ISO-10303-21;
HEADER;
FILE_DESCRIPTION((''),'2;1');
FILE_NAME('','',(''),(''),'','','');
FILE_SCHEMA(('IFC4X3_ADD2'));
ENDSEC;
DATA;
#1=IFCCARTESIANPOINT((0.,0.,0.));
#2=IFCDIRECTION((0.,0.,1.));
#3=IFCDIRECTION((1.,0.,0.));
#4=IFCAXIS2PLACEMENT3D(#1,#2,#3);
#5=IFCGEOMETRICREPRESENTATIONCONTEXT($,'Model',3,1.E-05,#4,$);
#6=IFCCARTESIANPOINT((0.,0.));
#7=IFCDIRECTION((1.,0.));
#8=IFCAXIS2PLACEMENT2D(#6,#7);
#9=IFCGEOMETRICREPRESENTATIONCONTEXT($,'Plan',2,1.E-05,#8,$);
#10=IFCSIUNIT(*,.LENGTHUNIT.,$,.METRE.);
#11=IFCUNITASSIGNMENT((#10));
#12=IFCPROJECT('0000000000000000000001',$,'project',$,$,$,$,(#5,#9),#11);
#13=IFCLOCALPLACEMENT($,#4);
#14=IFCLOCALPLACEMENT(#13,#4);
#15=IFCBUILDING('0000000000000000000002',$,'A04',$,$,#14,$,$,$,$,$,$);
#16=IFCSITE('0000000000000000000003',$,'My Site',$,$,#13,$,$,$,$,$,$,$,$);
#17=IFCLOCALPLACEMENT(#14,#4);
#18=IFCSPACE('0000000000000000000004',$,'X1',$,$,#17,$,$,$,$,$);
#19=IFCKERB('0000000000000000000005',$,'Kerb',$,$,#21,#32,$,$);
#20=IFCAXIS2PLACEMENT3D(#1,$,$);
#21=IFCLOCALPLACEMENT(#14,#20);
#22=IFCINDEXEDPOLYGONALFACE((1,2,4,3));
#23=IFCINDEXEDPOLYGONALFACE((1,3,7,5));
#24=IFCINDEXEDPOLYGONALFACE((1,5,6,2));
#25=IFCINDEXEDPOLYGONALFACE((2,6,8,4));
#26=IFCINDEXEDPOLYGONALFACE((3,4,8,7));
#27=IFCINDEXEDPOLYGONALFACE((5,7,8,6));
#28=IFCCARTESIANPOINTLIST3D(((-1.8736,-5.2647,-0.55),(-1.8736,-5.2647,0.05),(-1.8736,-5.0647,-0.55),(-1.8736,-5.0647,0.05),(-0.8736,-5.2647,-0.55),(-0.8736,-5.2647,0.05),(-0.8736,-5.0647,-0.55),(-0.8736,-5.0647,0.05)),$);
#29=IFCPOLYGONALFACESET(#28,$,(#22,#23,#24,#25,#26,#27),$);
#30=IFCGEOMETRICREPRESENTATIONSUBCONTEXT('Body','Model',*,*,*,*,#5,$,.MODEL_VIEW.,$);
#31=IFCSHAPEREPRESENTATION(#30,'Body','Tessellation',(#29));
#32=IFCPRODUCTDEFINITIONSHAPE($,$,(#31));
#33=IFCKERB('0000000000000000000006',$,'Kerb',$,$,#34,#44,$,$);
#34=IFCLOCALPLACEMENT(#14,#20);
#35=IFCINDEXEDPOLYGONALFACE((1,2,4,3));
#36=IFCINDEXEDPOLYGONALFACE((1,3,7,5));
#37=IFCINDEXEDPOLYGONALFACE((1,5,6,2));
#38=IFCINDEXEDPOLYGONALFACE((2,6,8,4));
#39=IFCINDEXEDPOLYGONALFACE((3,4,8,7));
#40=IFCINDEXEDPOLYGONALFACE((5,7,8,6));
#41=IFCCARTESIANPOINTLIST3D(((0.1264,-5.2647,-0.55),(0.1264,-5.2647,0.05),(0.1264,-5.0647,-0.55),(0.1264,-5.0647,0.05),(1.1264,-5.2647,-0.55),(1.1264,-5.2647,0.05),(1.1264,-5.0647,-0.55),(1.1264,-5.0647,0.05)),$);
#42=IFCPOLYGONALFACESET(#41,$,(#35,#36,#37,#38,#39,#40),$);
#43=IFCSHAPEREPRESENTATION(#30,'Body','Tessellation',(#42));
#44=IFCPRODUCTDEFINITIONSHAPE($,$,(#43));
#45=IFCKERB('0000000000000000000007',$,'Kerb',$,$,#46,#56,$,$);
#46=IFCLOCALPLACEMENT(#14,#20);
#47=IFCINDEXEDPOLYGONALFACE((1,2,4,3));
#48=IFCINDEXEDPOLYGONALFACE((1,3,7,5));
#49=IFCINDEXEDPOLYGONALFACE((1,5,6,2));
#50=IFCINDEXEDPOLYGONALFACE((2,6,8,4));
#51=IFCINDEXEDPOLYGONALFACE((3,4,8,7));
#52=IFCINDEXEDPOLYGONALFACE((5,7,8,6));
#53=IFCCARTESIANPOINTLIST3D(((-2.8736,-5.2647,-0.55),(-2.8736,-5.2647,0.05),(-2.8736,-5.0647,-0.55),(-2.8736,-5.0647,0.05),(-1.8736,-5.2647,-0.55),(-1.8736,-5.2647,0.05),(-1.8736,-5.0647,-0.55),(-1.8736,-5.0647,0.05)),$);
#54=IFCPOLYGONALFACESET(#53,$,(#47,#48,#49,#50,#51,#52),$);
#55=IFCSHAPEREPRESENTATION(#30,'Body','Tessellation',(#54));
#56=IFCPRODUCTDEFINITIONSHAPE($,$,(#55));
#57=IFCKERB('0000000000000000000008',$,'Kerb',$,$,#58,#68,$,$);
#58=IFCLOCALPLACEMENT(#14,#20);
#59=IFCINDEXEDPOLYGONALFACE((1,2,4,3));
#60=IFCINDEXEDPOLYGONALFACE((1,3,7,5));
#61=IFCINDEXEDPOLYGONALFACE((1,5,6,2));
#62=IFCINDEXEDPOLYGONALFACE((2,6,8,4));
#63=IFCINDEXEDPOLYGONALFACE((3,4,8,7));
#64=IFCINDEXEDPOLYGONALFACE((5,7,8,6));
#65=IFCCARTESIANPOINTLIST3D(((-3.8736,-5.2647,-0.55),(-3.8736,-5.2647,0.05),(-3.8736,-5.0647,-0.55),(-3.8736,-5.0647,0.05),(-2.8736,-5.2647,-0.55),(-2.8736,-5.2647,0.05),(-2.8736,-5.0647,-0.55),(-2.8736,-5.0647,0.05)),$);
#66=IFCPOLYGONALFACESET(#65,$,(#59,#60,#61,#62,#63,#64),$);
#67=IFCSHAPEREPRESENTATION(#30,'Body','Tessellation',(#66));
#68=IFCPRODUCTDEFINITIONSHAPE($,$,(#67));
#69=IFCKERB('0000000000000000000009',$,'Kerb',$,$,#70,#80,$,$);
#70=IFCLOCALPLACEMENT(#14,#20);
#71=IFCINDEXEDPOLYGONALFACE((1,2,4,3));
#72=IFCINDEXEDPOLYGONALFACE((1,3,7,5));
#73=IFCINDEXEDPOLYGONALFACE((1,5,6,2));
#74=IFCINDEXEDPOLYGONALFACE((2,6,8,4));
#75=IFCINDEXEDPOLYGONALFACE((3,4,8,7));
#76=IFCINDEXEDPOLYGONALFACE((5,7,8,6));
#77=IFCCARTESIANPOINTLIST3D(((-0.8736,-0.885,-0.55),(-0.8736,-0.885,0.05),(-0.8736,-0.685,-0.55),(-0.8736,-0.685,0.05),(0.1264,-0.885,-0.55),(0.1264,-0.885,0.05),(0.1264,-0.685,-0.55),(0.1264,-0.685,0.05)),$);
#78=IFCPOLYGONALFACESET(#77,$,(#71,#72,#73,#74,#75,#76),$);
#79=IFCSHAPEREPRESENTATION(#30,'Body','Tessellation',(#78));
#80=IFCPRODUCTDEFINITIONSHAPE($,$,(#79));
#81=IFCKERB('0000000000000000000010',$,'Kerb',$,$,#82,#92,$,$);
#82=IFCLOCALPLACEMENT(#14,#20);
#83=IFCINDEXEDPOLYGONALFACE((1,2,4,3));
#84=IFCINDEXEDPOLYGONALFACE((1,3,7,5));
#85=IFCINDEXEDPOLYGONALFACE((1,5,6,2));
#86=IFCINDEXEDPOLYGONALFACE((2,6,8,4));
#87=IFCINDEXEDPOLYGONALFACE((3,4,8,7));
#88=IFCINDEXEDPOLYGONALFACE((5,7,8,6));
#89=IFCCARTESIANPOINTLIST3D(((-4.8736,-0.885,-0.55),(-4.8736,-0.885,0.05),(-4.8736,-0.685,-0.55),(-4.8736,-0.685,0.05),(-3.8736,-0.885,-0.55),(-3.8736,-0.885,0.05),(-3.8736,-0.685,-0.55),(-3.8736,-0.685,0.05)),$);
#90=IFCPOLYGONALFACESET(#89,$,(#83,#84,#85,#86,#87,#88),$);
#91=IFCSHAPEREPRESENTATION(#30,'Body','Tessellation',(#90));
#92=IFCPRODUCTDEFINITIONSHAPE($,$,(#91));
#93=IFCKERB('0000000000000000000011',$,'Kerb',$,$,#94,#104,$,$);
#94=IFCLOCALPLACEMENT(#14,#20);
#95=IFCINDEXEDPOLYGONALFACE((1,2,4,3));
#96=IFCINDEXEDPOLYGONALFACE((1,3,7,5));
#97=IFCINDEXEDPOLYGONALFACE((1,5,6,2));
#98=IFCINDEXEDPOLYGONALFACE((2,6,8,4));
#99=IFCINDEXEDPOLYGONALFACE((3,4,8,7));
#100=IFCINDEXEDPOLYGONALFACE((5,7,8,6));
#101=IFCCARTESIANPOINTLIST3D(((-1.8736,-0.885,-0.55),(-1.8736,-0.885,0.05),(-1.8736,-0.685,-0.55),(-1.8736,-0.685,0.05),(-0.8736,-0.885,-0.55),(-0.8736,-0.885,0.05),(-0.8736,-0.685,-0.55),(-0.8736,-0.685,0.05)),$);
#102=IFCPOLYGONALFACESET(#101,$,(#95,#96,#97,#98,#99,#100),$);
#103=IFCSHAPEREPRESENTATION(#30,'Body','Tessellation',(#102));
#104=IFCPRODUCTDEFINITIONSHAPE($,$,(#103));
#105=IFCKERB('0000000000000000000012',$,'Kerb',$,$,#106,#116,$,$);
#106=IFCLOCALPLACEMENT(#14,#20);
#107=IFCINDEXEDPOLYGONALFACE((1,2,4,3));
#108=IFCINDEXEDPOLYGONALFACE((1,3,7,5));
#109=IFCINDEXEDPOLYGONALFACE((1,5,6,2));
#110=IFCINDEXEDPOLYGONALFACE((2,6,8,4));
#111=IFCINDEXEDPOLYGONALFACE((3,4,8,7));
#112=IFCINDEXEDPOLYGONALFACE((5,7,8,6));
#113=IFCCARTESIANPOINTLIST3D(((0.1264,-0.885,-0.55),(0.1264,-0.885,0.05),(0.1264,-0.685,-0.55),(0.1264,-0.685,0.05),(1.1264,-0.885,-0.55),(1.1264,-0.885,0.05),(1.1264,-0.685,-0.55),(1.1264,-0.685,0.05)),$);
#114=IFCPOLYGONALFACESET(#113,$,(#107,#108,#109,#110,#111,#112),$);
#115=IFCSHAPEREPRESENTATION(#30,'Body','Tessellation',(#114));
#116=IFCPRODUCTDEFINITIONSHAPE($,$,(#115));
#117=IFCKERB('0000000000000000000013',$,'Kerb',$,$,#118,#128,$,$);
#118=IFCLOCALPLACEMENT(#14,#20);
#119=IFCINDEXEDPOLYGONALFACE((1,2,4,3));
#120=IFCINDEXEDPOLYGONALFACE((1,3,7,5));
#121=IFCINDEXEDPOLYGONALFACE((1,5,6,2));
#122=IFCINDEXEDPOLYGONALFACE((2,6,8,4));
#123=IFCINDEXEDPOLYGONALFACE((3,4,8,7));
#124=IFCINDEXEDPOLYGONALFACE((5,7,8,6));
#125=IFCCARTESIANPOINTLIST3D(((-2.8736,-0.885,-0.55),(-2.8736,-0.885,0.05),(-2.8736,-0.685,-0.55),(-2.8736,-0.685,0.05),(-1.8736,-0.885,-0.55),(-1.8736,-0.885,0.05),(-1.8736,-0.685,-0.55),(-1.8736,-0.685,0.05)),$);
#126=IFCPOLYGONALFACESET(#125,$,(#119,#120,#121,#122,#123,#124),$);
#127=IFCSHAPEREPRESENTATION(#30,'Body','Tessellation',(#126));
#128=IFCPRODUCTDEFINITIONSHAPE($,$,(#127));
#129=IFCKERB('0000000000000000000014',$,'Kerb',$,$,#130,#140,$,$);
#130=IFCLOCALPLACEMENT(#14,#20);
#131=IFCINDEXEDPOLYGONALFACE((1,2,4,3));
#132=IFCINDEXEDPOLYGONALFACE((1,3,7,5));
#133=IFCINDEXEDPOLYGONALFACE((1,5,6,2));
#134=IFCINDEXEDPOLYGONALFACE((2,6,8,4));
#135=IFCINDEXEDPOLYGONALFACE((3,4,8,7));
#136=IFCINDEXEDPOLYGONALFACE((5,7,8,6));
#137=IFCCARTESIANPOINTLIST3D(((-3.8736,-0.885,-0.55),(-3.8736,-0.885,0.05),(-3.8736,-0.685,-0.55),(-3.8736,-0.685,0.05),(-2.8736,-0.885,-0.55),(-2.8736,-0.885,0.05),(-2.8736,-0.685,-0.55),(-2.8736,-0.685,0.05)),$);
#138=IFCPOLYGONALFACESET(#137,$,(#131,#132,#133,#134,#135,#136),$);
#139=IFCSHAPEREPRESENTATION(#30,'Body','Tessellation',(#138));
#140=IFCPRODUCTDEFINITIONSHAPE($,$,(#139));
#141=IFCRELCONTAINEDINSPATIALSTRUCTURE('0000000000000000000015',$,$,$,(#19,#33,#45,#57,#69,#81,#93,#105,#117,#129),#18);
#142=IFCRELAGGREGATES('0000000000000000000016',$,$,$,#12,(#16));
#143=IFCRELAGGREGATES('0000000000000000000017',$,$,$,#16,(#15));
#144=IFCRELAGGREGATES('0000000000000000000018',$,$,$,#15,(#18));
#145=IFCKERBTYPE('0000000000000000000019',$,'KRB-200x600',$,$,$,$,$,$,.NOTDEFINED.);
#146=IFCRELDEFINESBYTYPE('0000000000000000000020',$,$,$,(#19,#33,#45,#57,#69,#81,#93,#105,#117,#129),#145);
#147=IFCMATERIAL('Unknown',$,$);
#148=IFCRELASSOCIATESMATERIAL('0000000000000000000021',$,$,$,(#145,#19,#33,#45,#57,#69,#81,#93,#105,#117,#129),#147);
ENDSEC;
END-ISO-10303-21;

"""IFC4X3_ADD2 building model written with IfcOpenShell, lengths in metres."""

from ifc_helpers import new_model, si_unit, frame, origin_with_axes, origin_2d_with_axis, place, context, subcontext, project, spatial, rectangle, extrude, material, material_profile, profile_set, profile_usage, type_object, element, save


model = new_model("IFC4X3_ADD2")

# Units and contexts
model_context = context("Model", 3, precision=1e-05, world=origin_with_axes())
plan_context = context("Plan", 2, precision=1e-05, world=origin_2d_with_axis())
body_context = subcontext(model_context, "Body", "Model", "MODEL_VIEW")
ifc_project = project(units=[si_unit("LENGTHUNIT", "METRE")], contexts=[model_context, plan_context])

# Site, building, space
site_placement = place(None, origin_with_axes())
site = spatial("IfcSite", under=ifc_project, at=site_placement, Name="My Site")
building_placement = place(site_placement, origin_with_axes())
building = spatial("IfcBuilding", under=site, at=building_placement, Name="A04")
space_placement = place(building_placement, origin_with_axes())
space = spatial("IfcSpace", under=building, at=space_placement, Name="X1")

# Shared definitions
ifc_material = material(Name="Unknown")

# Kerbs
ifc_material_profile = material_profile(ifc_material, rectangle(XDim=0.2, YDim=0.6))
ifc_profile_set = profile_set([ifc_material_profile])
kerb_type = type_object("IfcKerbType", Name="KRB-200x600", PredefinedType="NOTDEFINED", material=ifc_profile_set)
ifc_profile_usage_1 = profile_usage(ifc_profile_set, cardinal=2)
kerb_1_placement = place(space_placement, frame((-1.8736, -5.1647, -0.55), z_axis=(1.0, 0.0, 0.0), x_axis=(0.0, 1.0, 0.0)))
element("IfcKerb", 1, at=kerb_1_placement, inside=space, type_object=kerb_type, material=ifc_profile_usage_1, Name="Kerb", context=body_context, shape_type="SweptSolid", body=[
    extrude(rectangle(XDim=0.2, YDim=0.6), frame((0.0, 0.3, 0.0), z_axis=(0.0, 0.0, 1.0), x_axis=(1.0, 0.0, 0.0)), (0.0, 0.0, 1.0), 1.0),
])
ifc_profile_usage_2 = profile_usage(ifc_profile_set, cardinal=2)
kerb_2_placement = place(space_placement, frame((0.1264, -5.1647, -0.55), z_axis=(1.0, 0.0, 0.0), x_axis=(0.0, 1.0, 0.0)))
element("IfcKerb", 2, at=kerb_2_placement, inside=space, type_object=kerb_type, material=ifc_profile_usage_2, Name="Kerb", context=body_context, shape_type="SweptSolid", body=[
    extrude(rectangle(XDim=0.2, YDim=0.6), frame((0.0, 0.3, 0.0), z_axis=(0.0, 0.0, 1.0), x_axis=(1.0, 0.0, 0.0)), (0.0, 0.0, 1.0), 1.0),
])
ifc_profile_usage_3 = profile_usage(ifc_profile_set, cardinal=2)
kerb_3_placement = place(space_placement, frame((-2.8736, -5.1647, -0.55), z_axis=(1.0, 0.0, 0.0), x_axis=(0.0, 1.0, 0.0)))
element("IfcKerb", 3, at=kerb_3_placement, inside=space, type_object=kerb_type, material=ifc_profile_usage_3, Name="Kerb", context=body_context, shape_type="SweptSolid", body=[
    extrude(rectangle(XDim=0.2, YDim=0.6), frame((0.0, 0.3, 0.0), z_axis=(0.0, 0.0, 1.0), x_axis=(1.0, 0.0, 0.0)), (0.0, 0.0, 1.0), 1.0),
])
ifc_profile_usage_4 = profile_usage(ifc_profile_set, cardinal=2)
kerb_4_placement = place(space_placement, frame((-3.8736, -5.1647, -0.55), z_axis=(1.0, 0.0, 0.0), x_axis=(0.0, 1.0, 0.0)))
element("IfcKerb", 4, at=kerb_4_placement, inside=space, type_object=kerb_type, material=ifc_profile_usage_4, Name="Kerb", context=body_context, shape_type="SweptSolid", body=[
    extrude(rectangle(XDim=0.2, YDim=0.6), frame((0.0, 0.3, 0.0), z_axis=(0.0, 0.0, 1.0), x_axis=(1.0, 0.0, 0.0)), (0.0, 0.0, 1.0), 1.0),
])
ifc_profile_usage_5 = profile_usage(ifc_profile_set, cardinal=2)
kerb_5_placement = place(space_placement, frame((-0.8736, -0.785, -0.55), z_axis=(1.0, 0.0, 0.0), x_axis=(0.0, 1.0, 0.0)))
element("IfcKerb", 5, at=kerb_5_placement, inside=space, type_object=kerb_type, material=ifc_profile_usage_5, Name="Kerb", context=body_context, shape_type="SweptSolid", body=[
    extrude(rectangle(XDim=0.2, YDim=0.6), frame((0.0, 0.3, 0.0), z_axis=(0.0, 0.0, 1.0), x_axis=(1.0, 0.0, 0.0)), (0.0, 0.0, 1.0), 1.0),
])
ifc_profile_usage_6 = profile_usage(ifc_profile_set, cardinal=2)
kerb_6_placement = place(space_placement, frame((-4.8736, -0.785, -0.55), z_axis=(1.0, 0.0, 0.0), x_axis=(0.0, 1.0, 0.0)))
element("IfcKerb", 6, at=kerb_6_placement, inside=space, type_object=kerb_type, material=ifc_profile_usage_6, Name="Kerb", context=body_context, shape_type="SweptSolid", body=[
    extrude(rectangle(XDim=0.2, YDim=0.6), frame((0.0, 0.3, 0.0), z_axis=(0.0, 0.0, 1.0), x_axis=(1.0, 0.0, 0.0)), (0.0, 0.0, 1.0), 1.0),
])
ifc_profile_usage_7 = profile_usage(ifc_profile_set, cardinal=2)
kerb_7_placement = place(space_placement, frame((-1.8736, -0.785, -0.55), z_axis=(1.0, 0.0, 0.0), x_axis=(0.0, 1.0, 0.0)))
element("IfcKerb", 7, at=kerb_7_placement, inside=space, type_object=kerb_type, material=ifc_profile_usage_7, Name="Kerb", context=body_context, shape_type="SweptSolid", body=[
    extrude(rectangle(XDim=0.2, YDim=0.6), frame((0.0, 0.3, 0.0), z_axis=(0.0, 0.0, 1.0), x_axis=(1.0, 0.0, 0.0)), (0.0, 0.0, 1.0), 1.0),
])
ifc_profile_usage_8 = profile_usage(ifc_profile_set, cardinal=2)
kerb_8_placement = place(space_placement, frame((0.1264, -0.785, -0.55), z_axis=(1.0, 0.0, 0.0), x_axis=(0.0, 1.0, 0.0)))
element("IfcKerb", 8, at=kerb_8_placement, inside=space, type_object=kerb_type, material=ifc_profile_usage_8, Name="Kerb", context=body_context, shape_type="SweptSolid", body=[
    extrude(rectangle(XDim=0.2, YDim=0.6), frame((0.0, 0.3, 0.0), z_axis=(0.0, 0.0, 1.0), x_axis=(1.0, 0.0, 0.0)), (0.0, 0.0, 1.0), 1.0),
])
ifc_profile_usage_9 = profile_usage(ifc_profile_set, cardinal=2)
kerb_9_placement = place(space_placement, frame((-2.8736, -0.785, -0.55), z_axis=(1.0, 0.0, 0.0), x_axis=(0.0, 1.0, 0.0)))
element("IfcKerb", 9, at=kerb_9_placement, inside=space, type_object=kerb_type, material=ifc_profile_usage_9, Name="Kerb", context=body_context, shape_type="SweptSolid", body=[
    extrude(rectangle(XDim=0.2, YDim=0.6), frame((0.0, 0.3, 0.0), z_axis=(0.0, 0.0, 1.0), x_axis=(1.0, 0.0, 0.0)), (0.0, 0.0, 1.0), 1.0),
])
ifc_profile_usage_10 = profile_usage(ifc_profile_set, cardinal=2)
kerb_10_placement = place(space_placement, frame((-3.8736, -0.785, -0.55), z_axis=(1.0, 0.0, 0.0), x_axis=(0.0, 1.0, 0.0)))
element("IfcKerb", 10, at=kerb_10_placement, inside=space, type_object=kerb_type, material=ifc_profile_usage_10, Name="Kerb", context=body_context, shape_type="SweptSolid", body=[
    extrude(rectangle(XDim=0.2, YDim=0.6), frame((0.0, 0.3, 0.0), z_axis=(0.0, 0.0, 1.0), x_axis=(1.0, 0.0, 0.0)), (0.0, 0.0, 1.0), 1.0),
])

save(model, "model.ifc")
